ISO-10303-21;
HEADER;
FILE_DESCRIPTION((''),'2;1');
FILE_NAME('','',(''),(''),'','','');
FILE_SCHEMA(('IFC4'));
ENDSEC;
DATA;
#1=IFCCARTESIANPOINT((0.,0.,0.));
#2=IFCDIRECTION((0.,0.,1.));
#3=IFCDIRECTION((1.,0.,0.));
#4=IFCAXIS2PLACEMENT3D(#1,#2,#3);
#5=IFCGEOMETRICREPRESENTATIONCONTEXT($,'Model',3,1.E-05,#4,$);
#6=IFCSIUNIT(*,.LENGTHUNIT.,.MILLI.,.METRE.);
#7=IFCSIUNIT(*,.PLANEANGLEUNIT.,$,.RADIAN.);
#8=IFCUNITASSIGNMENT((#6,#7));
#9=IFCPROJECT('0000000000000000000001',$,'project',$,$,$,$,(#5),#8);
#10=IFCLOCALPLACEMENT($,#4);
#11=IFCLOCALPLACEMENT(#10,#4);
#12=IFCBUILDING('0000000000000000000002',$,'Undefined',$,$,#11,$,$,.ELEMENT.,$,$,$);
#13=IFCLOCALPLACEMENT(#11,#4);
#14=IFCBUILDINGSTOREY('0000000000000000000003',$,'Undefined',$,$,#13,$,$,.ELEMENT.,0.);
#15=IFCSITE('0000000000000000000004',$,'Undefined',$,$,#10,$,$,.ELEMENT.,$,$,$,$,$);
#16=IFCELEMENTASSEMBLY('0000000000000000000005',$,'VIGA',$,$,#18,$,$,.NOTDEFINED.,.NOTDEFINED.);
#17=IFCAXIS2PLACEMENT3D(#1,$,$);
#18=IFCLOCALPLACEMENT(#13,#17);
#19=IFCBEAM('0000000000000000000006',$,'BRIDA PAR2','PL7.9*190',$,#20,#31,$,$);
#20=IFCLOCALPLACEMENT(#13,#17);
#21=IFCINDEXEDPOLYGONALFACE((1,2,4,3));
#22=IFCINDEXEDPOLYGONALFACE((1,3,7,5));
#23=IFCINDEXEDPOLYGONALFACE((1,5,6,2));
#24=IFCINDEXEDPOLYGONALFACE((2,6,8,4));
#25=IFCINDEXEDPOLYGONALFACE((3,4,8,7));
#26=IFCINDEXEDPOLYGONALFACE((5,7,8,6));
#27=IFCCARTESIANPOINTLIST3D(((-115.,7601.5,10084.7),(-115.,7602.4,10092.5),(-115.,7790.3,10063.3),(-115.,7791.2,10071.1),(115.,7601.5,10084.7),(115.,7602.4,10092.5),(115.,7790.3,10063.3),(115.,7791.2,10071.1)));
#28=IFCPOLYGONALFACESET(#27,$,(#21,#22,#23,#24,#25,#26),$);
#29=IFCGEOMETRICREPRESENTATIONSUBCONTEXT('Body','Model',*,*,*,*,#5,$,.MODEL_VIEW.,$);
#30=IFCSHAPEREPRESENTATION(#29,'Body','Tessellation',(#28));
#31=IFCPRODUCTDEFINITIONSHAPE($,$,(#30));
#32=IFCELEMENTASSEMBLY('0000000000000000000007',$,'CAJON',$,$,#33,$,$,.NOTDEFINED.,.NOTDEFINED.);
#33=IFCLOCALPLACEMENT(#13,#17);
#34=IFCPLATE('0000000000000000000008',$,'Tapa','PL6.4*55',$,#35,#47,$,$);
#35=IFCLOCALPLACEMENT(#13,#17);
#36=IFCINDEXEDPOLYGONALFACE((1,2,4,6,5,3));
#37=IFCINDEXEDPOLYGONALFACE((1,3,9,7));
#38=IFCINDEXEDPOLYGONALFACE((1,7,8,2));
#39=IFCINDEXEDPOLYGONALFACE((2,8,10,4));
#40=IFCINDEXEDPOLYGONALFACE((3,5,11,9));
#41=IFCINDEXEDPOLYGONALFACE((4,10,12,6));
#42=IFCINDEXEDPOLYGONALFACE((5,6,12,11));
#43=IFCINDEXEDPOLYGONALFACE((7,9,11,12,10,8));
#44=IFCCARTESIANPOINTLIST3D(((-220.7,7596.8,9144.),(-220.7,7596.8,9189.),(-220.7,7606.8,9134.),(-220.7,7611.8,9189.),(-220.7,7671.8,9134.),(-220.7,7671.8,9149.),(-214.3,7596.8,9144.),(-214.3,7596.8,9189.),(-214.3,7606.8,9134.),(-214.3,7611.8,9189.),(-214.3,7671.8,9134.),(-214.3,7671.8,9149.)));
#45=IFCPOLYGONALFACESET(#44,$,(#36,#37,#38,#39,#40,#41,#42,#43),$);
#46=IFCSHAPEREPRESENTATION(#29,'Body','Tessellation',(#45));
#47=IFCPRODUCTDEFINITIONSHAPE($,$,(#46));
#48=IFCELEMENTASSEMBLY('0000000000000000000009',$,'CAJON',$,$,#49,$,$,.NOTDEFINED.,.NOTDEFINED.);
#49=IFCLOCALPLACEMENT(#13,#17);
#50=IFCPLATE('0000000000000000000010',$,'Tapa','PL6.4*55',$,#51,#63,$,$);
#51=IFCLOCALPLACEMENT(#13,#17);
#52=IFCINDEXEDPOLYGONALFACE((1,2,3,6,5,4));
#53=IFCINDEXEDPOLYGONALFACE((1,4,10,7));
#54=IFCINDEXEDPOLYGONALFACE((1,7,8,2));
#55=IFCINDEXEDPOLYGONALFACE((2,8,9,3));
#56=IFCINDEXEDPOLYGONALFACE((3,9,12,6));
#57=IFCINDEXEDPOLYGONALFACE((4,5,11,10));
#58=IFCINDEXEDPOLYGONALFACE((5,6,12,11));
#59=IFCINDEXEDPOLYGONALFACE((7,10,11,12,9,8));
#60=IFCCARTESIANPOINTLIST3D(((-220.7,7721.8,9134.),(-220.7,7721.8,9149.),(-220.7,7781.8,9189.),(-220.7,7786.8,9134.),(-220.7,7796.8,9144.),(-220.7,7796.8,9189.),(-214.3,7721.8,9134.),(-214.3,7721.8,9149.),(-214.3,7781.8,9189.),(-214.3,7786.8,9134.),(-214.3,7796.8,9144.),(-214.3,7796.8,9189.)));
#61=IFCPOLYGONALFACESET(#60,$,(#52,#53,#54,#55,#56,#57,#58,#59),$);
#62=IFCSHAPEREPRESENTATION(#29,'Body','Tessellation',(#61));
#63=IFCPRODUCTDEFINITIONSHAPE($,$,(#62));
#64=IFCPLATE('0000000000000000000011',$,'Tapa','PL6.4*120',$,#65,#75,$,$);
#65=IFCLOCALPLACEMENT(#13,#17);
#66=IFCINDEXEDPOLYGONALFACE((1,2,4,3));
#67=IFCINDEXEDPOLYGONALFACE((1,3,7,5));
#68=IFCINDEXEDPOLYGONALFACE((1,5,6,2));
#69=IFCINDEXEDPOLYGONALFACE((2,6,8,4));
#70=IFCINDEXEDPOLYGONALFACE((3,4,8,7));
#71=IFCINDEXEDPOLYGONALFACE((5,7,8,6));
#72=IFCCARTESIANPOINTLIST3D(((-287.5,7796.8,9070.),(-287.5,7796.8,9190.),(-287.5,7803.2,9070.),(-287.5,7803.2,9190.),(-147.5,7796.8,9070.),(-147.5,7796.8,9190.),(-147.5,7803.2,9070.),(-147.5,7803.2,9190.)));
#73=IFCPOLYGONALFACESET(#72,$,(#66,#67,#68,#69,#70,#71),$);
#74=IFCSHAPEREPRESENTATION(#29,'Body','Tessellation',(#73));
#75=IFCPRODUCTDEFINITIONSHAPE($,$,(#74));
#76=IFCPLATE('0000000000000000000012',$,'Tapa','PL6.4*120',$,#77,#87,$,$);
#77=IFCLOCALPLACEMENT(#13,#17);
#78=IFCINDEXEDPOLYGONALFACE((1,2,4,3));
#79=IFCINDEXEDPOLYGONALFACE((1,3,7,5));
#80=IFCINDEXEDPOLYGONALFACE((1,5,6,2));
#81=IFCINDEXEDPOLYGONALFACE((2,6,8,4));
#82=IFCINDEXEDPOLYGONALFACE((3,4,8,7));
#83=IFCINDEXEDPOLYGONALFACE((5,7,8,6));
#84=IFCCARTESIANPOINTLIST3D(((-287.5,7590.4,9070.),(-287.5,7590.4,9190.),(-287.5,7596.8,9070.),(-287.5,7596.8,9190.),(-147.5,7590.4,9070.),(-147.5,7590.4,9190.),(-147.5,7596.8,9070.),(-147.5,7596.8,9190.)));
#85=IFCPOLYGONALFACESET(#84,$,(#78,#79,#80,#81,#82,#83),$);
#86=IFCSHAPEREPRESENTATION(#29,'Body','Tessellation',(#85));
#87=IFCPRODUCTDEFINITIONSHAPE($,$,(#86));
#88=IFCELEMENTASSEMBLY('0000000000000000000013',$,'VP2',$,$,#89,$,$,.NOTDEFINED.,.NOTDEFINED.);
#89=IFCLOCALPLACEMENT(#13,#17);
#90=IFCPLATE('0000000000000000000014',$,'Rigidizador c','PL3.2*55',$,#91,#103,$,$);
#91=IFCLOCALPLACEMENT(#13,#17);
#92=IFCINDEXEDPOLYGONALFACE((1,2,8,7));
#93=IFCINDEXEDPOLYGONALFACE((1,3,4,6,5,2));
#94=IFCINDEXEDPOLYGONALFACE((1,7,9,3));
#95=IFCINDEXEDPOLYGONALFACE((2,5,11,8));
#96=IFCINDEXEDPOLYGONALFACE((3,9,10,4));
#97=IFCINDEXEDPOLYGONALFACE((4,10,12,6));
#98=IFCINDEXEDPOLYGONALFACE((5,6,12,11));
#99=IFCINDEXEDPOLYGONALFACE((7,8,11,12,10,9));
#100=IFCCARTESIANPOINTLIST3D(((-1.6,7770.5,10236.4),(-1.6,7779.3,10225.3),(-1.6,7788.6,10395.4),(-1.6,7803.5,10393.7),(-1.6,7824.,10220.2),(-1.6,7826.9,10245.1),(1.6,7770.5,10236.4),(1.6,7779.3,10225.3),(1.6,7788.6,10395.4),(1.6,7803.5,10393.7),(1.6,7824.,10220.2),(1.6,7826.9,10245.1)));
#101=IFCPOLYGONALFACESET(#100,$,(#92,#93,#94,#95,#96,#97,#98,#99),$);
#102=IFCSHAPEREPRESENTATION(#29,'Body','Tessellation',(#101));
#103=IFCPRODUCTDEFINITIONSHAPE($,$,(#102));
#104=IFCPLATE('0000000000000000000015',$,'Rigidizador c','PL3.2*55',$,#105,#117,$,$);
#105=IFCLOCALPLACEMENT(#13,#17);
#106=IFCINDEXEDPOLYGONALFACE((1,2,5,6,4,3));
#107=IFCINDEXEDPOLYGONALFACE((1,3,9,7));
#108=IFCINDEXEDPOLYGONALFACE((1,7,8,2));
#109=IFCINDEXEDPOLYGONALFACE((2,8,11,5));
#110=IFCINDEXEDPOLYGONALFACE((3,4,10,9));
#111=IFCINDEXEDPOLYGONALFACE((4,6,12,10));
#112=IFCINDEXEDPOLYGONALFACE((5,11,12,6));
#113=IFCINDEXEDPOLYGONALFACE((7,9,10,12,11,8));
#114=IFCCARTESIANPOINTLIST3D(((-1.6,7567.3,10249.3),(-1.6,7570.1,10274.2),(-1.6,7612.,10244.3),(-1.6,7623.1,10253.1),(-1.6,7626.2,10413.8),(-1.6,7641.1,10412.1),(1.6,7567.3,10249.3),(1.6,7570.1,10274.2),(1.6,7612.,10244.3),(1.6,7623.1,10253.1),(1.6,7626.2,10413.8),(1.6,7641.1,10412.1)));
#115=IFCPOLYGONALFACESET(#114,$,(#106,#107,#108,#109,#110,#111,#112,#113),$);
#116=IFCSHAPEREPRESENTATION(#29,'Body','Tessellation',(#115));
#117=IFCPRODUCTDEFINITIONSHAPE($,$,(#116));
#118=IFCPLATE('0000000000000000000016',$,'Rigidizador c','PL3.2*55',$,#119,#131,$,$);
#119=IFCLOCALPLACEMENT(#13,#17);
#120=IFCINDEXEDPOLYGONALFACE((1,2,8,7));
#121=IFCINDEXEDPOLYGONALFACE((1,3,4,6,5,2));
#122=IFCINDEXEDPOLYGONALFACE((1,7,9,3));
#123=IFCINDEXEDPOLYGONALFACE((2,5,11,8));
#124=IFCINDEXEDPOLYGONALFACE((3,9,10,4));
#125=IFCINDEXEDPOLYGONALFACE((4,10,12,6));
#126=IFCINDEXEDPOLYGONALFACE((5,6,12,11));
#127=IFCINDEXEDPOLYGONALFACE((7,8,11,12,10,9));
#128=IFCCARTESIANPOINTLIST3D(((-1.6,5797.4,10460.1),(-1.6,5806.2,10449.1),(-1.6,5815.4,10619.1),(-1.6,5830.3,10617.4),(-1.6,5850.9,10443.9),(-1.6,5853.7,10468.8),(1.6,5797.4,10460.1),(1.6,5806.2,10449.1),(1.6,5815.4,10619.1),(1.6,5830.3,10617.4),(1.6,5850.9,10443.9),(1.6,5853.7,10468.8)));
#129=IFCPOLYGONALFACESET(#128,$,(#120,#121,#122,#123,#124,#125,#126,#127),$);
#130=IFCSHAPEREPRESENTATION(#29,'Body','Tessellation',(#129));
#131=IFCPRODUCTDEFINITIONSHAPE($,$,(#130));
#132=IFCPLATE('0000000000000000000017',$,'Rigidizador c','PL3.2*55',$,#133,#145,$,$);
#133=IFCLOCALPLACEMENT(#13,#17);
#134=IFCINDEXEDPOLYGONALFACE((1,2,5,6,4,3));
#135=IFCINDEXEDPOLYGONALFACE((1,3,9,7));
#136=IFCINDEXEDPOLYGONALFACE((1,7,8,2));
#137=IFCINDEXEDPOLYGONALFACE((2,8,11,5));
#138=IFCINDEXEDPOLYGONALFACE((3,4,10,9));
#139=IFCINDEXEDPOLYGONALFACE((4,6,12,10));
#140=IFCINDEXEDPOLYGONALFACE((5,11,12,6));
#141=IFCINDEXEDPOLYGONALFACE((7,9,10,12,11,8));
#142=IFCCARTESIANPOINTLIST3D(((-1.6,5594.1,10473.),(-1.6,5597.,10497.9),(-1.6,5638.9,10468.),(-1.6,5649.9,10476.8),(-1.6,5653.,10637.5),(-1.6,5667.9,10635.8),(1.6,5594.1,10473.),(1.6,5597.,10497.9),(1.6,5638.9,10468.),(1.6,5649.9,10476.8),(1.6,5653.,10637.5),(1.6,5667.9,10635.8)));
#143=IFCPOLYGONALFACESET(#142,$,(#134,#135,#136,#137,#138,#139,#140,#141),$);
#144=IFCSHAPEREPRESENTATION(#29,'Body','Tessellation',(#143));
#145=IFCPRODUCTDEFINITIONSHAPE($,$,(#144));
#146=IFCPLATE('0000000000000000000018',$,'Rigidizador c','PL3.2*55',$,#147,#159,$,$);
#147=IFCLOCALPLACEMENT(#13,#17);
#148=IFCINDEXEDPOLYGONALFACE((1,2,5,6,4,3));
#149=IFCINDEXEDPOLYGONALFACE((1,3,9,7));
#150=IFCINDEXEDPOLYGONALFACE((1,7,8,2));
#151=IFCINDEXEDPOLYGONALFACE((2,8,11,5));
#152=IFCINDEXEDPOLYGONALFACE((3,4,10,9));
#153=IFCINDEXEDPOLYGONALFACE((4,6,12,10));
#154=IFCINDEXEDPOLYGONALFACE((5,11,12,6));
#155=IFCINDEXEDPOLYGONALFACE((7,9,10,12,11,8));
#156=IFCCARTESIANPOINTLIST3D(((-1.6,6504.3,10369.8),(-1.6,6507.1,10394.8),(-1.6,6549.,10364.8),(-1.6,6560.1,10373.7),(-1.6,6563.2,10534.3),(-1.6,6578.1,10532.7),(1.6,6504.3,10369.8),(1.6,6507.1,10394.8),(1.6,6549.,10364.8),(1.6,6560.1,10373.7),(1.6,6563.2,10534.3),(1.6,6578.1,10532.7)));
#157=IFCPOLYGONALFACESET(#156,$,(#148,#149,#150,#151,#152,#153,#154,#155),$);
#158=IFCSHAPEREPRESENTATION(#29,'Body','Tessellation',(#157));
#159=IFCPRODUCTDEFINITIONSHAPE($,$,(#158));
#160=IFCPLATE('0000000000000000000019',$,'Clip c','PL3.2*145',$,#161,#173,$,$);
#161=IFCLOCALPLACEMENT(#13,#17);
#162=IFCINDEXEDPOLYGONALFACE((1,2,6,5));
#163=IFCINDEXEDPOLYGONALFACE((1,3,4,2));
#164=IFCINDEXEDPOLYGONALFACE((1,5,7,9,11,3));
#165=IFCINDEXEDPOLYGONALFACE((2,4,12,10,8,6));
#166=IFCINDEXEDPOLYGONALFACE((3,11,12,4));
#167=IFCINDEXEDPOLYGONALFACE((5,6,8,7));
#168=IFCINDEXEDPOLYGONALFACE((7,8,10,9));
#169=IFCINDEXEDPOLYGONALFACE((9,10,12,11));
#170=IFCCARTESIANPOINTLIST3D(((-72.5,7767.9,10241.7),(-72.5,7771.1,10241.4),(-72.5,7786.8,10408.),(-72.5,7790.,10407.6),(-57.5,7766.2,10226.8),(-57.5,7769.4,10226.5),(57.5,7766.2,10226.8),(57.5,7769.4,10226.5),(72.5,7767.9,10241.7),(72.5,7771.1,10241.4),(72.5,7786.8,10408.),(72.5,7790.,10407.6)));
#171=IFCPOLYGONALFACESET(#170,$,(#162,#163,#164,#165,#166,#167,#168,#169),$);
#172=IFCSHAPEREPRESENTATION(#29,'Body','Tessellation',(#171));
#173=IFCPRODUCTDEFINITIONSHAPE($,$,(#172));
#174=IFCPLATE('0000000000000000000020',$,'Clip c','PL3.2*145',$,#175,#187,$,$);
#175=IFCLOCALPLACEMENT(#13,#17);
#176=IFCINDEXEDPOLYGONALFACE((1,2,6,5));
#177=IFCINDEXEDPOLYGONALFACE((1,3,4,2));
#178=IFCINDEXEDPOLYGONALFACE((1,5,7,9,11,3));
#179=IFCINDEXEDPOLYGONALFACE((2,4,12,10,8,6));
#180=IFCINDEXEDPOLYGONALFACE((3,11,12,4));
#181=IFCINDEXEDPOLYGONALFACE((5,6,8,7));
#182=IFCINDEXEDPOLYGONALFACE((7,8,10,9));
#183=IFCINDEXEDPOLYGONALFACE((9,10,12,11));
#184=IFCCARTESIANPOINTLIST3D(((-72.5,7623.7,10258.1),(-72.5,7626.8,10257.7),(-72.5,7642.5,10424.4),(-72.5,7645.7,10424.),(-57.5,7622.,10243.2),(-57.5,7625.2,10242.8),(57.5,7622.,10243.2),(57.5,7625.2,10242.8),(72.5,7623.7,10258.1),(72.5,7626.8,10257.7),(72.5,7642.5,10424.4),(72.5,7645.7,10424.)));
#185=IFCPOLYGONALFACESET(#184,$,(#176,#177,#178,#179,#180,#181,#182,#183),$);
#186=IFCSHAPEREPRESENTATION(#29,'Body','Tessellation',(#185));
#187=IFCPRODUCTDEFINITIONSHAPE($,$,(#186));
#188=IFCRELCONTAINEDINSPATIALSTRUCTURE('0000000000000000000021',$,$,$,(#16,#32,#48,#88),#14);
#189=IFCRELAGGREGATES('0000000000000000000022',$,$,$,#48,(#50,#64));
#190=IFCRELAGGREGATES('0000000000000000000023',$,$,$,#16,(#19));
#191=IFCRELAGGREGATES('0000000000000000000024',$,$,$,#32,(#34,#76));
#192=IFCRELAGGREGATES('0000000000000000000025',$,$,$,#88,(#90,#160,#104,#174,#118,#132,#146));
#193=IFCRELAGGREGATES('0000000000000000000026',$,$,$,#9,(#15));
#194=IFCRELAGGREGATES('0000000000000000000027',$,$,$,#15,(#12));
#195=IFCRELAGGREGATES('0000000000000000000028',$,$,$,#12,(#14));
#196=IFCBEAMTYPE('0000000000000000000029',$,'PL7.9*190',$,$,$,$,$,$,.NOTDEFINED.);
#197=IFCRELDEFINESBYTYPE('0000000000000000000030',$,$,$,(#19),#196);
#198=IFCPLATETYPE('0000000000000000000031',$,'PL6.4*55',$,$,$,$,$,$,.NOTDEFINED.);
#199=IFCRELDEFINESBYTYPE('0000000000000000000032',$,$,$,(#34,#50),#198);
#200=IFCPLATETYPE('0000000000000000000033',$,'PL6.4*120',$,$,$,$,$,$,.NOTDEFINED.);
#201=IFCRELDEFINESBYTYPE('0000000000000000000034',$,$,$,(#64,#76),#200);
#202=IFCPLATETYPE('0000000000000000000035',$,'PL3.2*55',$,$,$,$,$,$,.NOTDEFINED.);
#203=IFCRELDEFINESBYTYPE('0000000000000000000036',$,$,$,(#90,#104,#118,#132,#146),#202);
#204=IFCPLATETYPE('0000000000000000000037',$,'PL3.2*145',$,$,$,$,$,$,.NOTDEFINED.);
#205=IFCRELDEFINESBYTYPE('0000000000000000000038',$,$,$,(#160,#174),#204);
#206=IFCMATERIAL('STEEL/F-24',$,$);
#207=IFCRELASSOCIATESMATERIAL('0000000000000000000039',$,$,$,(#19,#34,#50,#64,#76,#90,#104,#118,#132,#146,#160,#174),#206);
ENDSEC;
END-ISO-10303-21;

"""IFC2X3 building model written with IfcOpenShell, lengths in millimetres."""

from ifc_helpers import new_model, si_unit, frame, origin_with_axes, origin_2d_with_axis, place, context, subcontext, project, spatial, polyline, rectangle, outline, extrude, material, type_object, element, aggregate, save


model = new_model("IFC2X3")

# Units and contexts
model_context = context("Model", 3, precision=1e-05, world=origin_with_axes())
body_context = subcontext(model_context, "Body", "Model", "MODEL_VIEW")
ifc_project = project(units=[si_unit("LENGTHUNIT", "METRE", prefix="MILLI"), si_unit("PLANEANGLEUNIT", "RADIAN")], contexts=[model_context])

# Site, building, storey
site_placement = place(None, origin_with_axes())
site = spatial("IfcSite", under=ifc_project, at=site_placement, Name="Undefined", CompositionType="ELEMENT")
building_placement = place(site_placement, origin_with_axes())
building = spatial("IfcBuilding", under=site, at=building_placement, Name="Undefined", CompositionType="ELEMENT")
storey_placement = place(building_placement, origin_with_axes())
storey = spatial("IfcBuildingStorey", under=building, at=storey_placement, Name="Undefined", CompositionType="ELEMENT", Elevation=0.0)

# Element assembly, beam
assembly_1_placement = place(storey_placement, origin_with_axes())
assembly_1 = element("IfcElementAssembly", 1, at=assembly_1_placement, inside=storey, Name="VIGA", AssemblyPlace="NOTDEFINED", PredefinedType="NOTDEFINED")
ifc_material_1 = material(Name="STEEL/F-24")
beam_type = type_object("IfcBeamType", Name="PL7.9*190", PredefinedType="NOTDEFINED")
beam_placement = place(assembly_1_placement, frame((-115.0, 7696.4, 10077.9), z_axis=(0.0, 0.993634, -0.112653), x_axis=(1.0, 0.0, 0.0)))
beam = element("IfcBeam", 2, at=beam_placement, type_object=beam_type, material=ifc_material_1, Name="BRIDA PAR2", Description="PL7.9*190", context=body_context, shape_type="SweptSolid", body=[
    extrude(rectangle(XDim=7.9, YDim=190.0, at=origin_2d_with_axis()), frame((230.0, 0.0, 0.0), z_axis=(-1.0, 0.0, 0.0), x_axis=(0.0, -1.0, 0.0)), (0.0, 0.0, 1.0), 230.0),
])

# Element assembly, plate
assembly_2_placement = place(storey_placement, origin_with_axes())
assembly_2 = element("IfcElementAssembly", 3, at=assembly_2_placement, inside=storey, Name="CAJON", AssemblyPlace="NOTDEFINED", PredefinedType="NOTDEFINED")
plate_type_1 = type_object("IfcPlateType", Name="PL6.4*55", PredefinedType="NOTDEFINED")
plate_1_placement = place(assembly_2_placement, frame((-217.5, 7671.8, 9134.0), z_axis=(-1.0, 0.0, 0.0), x_axis=(0.0, -1.0, 0.0)))
plate_1 = element("IfcPlate", 4, at=plate_1_placement, type_object=plate_type_1, material=ifc_material_1, Name="Tapa", Description="PL6.4*55", context=body_context, shape_type="SweptSolid", body=[
    extrude(outline(polyline([(0.0, 0.0), (65.0, 0.0), (75.0, 10.0), (75.0, 55.0), (60.0, 55.0), (0.0, 15.0), (0.0, 0.0)])), frame((0.0, 0.0, -3.2), z_axis=(0.0, 0.0, 1.0), x_axis=(1.0, 0.0, 0.0)), (0.0, 0.0, 1.0), 6.4),
])

# Element assembly, plates
assembly_3_placement = place(storey_placement, origin_with_axes())
assembly_3 = element("IfcElementAssembly", 5, at=assembly_3_placement, inside=storey, Name="CAJON", AssemblyPlace="NOTDEFINED", PredefinedType="NOTDEFINED")
plate_2_placement = place(assembly_3_placement, frame((-217.5, 7721.8, 9134.0), z_axis=(1.0, 0.0, 0.0), x_axis=(0.0, 1.0, 0.0)))
plate_2 = element("IfcPlate", 6, at=plate_2_placement, type_object=plate_type_1, material=ifc_material_1, Name="Tapa", Description="PL6.4*55", context=body_context, shape_type="SweptSolid", body=[
    extrude(outline(polyline([(0.0, 0.0), (65.0, 0.0), (75.0, 10.0), (75.0, 55.0), (60.0, 55.0), (0.0, 15.0), (0.0, 0.0)])), frame((0.0, 0.0, -3.2), z_axis=(0.0, 0.0, 1.0), x_axis=(1.0, 0.0, 0.0)), (0.0, 0.0, 1.0), 6.4),
])
plate_type_2 = type_object("IfcPlateType", Name="PL6.4*120", PredefinedType="NOTDEFINED")
plate_3_placement = place(assembly_3_placement, frame((-287.5, 7800.0, 9190.0), z_axis=(0.0, -1.0, 0.0), x_axis=(0.0, 0.0, -1.0)))
plate_3 = element("IfcPlate", 7, at=plate_3_placement, type_object=plate_type_2, material=ifc_material_1, Name="Tapa", Description="PL6.4*120", context=body_context, shape_type="SweptSolid", body=[
    extrude(outline(polyline([(0.0, 0.0), (120.0, 0.0), (120.0, 140.0), (0.0, 140.0), (0.0, 0.0)])), frame((0.0, 0.0, -3.2), z_axis=(0.0, 0.0, 1.0), x_axis=(1.0, 0.0, 0.0)), (0.0, 0.0, 1.0), 6.4),
])
aggregate(assembly_3, [plate_2, plate_3])

# Plate
plate_4_placement = place(assembly_2_placement, frame((-287.5, 7593.6, 9190.0), z_axis=(0.0, -1.0, 0.0), x_axis=(0.0, 0.0, -1.0)))
plate_4 = element("IfcPlate", 8, at=plate_4_placement, type_object=plate_type_2, material=ifc_material_1, Name="Tapa", Description="PL6.4*120", context=body_context, shape_type="SweptSolid", body=[
    extrude(outline(polyline([(0.0, 0.0), (120.0, 0.0), (120.0, 140.0), (0.0, 140.0), (0.0, 0.0)])), frame((0.0, 0.0, -3.2), z_axis=(0.0, 0.0, 1.0), x_axis=(1.0, 0.0, 0.0)), (0.0, 0.0, 1.0), 6.4),
])

# Element assembly, plates
assembly_4_placement = place(storey_placement, origin_with_axes())
assembly_4 = element("IfcElementAssembly", 9, at=assembly_4_placement, inside=storey, Name="VP2", AssemblyPlace="NOTDEFINED", PredefinedType="NOTDEFINED")
plate_type_3 = type_object("IfcPlateType", Name="PL3.2*55", PredefinedType="NOTDEFINED")
plate_5_placement = place(assembly_4_placement, frame((0.0, 7788.6, 10395.4), z_axis=(-1.0, 0.0, 0.0), x_axis=(0.0, 0.993635, -0.112644)))
plate_5 = element("IfcPlate", 10, at=plate_5_placement, type_object=plate_type_3, material=ifc_material_1, Name="Rigidizador c", Description="PL3.2*55", context=body_context, shape_type="SweptSolid", body=[
    extrude(outline(polyline([(0.0, 0.0), (15.0, 0.0), (55.0, 145.0), (55.0, 170.1), (10.0, 170.0), (0.0, 160.0), (0.0, 0.0)])), frame((0.0, 0.0, -1.6), z_axis=(0.0, 0.0, 1.0), x_axis=(1.0, 0.0, 0.0)), (0.0, 0.0, 1.0), 3.2),
])
plate_6_placement = place(assembly_4_placement, frame((0.0, 7641.1, 10412.1), z_axis=(1.0, 0.0, 0.0), x_axis=(0.0, -0.993635, 0.112644)))
plate_6 = element("IfcPlate", 11, at=plate_6_placement, type_object=plate_type_3, material=ifc_material_1, Name="Rigidizador c", Description="PL3.2*55", context=body_context, shape_type="SweptSolid", body=[
    extrude(outline(polyline([(0.0, 0.0), (15.0, 0.0), (55.0, 145.0), (55.0, 170.1), (10.0, 170.0), (0.0, 160.0), (0.0, 0.0)])), frame((0.0, 0.0, -1.6), z_axis=(0.0, 0.0, 1.0), x_axis=(1.0, 0.0, 0.0)), (0.0, 0.0, 1.0), 3.2),
])
plate_7_placement = place(assembly_4_placement, frame((0.0, 5815.4, 10619.1), z_axis=(-1.0, 0.0, 0.0), x_axis=(0.0, 0.993635, -0.112644)))
plate_7 = element("IfcPlate", 12, at=plate_7_placement, type_object=plate_type_3, material=ifc_material_1, Name="Rigidizador c", Description="PL3.2*55", context=body_context, shape_type="SweptSolid", body=[
    extrude(outline(polyline([(0.0, 0.0), (15.0, 0.0), (55.0, 145.0), (55.0, 170.1), (10.0, 170.0), (0.0, 160.0), (0.0, 0.0)])), frame((0.0, 0.0, -1.6), z_axis=(0.0, 0.0, 1.0), x_axis=(1.0, 0.0, 0.0)), (0.0, 0.0, 1.0), 3.2),
])
plate_8_placement = place(assembly_4_placement, frame((0.0, 5667.9, 10635.8), z_axis=(1.0, 0.0, 0.0), x_axis=(0.0, -0.993635, 0.112644)))
plate_8 = element("IfcPlate", 13, at=plate_8_placement, type_object=plate_type_3, material=ifc_material_1, Name="Rigidizador c", Description="PL3.2*55", context=body_context, shape_type="SweptSolid", body=[
    extrude(outline(polyline([(0.0, 0.0), (15.0, 0.0), (55.0, 145.0), (55.0, 170.1), (10.0, 170.0), (0.0, 160.0), (0.0, 0.0)])), frame((0.0, 0.0, -1.6), z_axis=(0.0, 0.0, 1.0), x_axis=(1.0, 0.0, 0.0)), (0.0, 0.0, 1.0), 3.2),
])
plate_9_placement = place(assembly_4_placement, frame((0.0, 6578.1, 10532.7), z_axis=(1.0, 0.0, 0.0), x_axis=(0.0, -0.993635, 0.112644)))
plate_9 = element("IfcPlate", 14, at=plate_9_placement, type_object=plate_type_3, material=ifc_material_1, Name="Rigidizador c", Description="PL3.2*55", context=body_context, shape_type="SweptSolid", body=[
    extrude(outline(polyline([(0.0, 0.0), (15.0, 0.0), (55.0, 145.0), (55.0, 170.1), (10.0, 170.0), (0.0, 160.0), (0.0, 0.0)])), frame((0.0, 0.0, -1.6), z_axis=(0.0, 0.0, 1.0), x_axis=(1.0, 0.0, 0.0)), (0.0, 0.0, 1.0), 3.2),
])
plate_type_4 = type_object("IfcPlateType", Name="PL3.2*145", PredefinedType="NOTDEFINED")
plate_10_placement = place(assembly_4_placement, frame((-72.5, 7767.8, 10226.6), z_axis=(0.0, 0.993626, -0.112729), x_axis=(0.0, 0.112729, 0.993626)))
plate_10 = element("IfcPlate", 15, at=plate_10_placement, type_object=plate_type_4, material=ifc_material_1, Name="Clip c", Description="PL3.2*145", context=body_context, shape_type="SweptSolid", body=[
    extrude(outline(polyline([(0.0, 15.0), (15.0, 0.0), (182.3, 0.0), (182.3, 145.0), (15.0, 145.0), (0.0, 130.0), (0.0, 15.0)])), frame((0.0, 0.0, -1.6), z_axis=(0.0, 0.0, 1.0), x_axis=(1.0, 0.0, 0.0)), (0.0, 0.0, 1.0), 3.2),
])
plate_11_placement = place(assembly_4_placement, frame((-72.5, 7623.6, 10243.0), z_axis=(0.0, 0.993645, -0.112559), x_axis=(0.0, 0.112559, 0.993645)))
plate_11 = element("IfcPlate", 16, at=plate_11_placement, type_object=plate_type_4, material=ifc_material_1, Name="Clip c", Description="PL3.2*145", context=body_context, shape_type="SweptSolid", body=[
    extrude(outline(polyline([(0.0, 15.0), (15.0, 0.0), (182.3, 0.0), (182.3, 145.0), (15.0, 145.0), (0.0, 130.0), (0.0, 15.0)])), frame((0.0, 0.0, -1.6), z_axis=(0.0, 0.0, 1.0), x_axis=(1.0, 0.0, 0.0)), (0.0, 0.0, 1.0), 3.2),
])

aggregate(assembly_1, [beam])

aggregate(assembly_2, [plate_1, plate_4])

aggregate(assembly_4, [plate_5, plate_10, plate_6, plate_11, plate_7, plate_8, plate_9])

save(model, "model.ifc")
